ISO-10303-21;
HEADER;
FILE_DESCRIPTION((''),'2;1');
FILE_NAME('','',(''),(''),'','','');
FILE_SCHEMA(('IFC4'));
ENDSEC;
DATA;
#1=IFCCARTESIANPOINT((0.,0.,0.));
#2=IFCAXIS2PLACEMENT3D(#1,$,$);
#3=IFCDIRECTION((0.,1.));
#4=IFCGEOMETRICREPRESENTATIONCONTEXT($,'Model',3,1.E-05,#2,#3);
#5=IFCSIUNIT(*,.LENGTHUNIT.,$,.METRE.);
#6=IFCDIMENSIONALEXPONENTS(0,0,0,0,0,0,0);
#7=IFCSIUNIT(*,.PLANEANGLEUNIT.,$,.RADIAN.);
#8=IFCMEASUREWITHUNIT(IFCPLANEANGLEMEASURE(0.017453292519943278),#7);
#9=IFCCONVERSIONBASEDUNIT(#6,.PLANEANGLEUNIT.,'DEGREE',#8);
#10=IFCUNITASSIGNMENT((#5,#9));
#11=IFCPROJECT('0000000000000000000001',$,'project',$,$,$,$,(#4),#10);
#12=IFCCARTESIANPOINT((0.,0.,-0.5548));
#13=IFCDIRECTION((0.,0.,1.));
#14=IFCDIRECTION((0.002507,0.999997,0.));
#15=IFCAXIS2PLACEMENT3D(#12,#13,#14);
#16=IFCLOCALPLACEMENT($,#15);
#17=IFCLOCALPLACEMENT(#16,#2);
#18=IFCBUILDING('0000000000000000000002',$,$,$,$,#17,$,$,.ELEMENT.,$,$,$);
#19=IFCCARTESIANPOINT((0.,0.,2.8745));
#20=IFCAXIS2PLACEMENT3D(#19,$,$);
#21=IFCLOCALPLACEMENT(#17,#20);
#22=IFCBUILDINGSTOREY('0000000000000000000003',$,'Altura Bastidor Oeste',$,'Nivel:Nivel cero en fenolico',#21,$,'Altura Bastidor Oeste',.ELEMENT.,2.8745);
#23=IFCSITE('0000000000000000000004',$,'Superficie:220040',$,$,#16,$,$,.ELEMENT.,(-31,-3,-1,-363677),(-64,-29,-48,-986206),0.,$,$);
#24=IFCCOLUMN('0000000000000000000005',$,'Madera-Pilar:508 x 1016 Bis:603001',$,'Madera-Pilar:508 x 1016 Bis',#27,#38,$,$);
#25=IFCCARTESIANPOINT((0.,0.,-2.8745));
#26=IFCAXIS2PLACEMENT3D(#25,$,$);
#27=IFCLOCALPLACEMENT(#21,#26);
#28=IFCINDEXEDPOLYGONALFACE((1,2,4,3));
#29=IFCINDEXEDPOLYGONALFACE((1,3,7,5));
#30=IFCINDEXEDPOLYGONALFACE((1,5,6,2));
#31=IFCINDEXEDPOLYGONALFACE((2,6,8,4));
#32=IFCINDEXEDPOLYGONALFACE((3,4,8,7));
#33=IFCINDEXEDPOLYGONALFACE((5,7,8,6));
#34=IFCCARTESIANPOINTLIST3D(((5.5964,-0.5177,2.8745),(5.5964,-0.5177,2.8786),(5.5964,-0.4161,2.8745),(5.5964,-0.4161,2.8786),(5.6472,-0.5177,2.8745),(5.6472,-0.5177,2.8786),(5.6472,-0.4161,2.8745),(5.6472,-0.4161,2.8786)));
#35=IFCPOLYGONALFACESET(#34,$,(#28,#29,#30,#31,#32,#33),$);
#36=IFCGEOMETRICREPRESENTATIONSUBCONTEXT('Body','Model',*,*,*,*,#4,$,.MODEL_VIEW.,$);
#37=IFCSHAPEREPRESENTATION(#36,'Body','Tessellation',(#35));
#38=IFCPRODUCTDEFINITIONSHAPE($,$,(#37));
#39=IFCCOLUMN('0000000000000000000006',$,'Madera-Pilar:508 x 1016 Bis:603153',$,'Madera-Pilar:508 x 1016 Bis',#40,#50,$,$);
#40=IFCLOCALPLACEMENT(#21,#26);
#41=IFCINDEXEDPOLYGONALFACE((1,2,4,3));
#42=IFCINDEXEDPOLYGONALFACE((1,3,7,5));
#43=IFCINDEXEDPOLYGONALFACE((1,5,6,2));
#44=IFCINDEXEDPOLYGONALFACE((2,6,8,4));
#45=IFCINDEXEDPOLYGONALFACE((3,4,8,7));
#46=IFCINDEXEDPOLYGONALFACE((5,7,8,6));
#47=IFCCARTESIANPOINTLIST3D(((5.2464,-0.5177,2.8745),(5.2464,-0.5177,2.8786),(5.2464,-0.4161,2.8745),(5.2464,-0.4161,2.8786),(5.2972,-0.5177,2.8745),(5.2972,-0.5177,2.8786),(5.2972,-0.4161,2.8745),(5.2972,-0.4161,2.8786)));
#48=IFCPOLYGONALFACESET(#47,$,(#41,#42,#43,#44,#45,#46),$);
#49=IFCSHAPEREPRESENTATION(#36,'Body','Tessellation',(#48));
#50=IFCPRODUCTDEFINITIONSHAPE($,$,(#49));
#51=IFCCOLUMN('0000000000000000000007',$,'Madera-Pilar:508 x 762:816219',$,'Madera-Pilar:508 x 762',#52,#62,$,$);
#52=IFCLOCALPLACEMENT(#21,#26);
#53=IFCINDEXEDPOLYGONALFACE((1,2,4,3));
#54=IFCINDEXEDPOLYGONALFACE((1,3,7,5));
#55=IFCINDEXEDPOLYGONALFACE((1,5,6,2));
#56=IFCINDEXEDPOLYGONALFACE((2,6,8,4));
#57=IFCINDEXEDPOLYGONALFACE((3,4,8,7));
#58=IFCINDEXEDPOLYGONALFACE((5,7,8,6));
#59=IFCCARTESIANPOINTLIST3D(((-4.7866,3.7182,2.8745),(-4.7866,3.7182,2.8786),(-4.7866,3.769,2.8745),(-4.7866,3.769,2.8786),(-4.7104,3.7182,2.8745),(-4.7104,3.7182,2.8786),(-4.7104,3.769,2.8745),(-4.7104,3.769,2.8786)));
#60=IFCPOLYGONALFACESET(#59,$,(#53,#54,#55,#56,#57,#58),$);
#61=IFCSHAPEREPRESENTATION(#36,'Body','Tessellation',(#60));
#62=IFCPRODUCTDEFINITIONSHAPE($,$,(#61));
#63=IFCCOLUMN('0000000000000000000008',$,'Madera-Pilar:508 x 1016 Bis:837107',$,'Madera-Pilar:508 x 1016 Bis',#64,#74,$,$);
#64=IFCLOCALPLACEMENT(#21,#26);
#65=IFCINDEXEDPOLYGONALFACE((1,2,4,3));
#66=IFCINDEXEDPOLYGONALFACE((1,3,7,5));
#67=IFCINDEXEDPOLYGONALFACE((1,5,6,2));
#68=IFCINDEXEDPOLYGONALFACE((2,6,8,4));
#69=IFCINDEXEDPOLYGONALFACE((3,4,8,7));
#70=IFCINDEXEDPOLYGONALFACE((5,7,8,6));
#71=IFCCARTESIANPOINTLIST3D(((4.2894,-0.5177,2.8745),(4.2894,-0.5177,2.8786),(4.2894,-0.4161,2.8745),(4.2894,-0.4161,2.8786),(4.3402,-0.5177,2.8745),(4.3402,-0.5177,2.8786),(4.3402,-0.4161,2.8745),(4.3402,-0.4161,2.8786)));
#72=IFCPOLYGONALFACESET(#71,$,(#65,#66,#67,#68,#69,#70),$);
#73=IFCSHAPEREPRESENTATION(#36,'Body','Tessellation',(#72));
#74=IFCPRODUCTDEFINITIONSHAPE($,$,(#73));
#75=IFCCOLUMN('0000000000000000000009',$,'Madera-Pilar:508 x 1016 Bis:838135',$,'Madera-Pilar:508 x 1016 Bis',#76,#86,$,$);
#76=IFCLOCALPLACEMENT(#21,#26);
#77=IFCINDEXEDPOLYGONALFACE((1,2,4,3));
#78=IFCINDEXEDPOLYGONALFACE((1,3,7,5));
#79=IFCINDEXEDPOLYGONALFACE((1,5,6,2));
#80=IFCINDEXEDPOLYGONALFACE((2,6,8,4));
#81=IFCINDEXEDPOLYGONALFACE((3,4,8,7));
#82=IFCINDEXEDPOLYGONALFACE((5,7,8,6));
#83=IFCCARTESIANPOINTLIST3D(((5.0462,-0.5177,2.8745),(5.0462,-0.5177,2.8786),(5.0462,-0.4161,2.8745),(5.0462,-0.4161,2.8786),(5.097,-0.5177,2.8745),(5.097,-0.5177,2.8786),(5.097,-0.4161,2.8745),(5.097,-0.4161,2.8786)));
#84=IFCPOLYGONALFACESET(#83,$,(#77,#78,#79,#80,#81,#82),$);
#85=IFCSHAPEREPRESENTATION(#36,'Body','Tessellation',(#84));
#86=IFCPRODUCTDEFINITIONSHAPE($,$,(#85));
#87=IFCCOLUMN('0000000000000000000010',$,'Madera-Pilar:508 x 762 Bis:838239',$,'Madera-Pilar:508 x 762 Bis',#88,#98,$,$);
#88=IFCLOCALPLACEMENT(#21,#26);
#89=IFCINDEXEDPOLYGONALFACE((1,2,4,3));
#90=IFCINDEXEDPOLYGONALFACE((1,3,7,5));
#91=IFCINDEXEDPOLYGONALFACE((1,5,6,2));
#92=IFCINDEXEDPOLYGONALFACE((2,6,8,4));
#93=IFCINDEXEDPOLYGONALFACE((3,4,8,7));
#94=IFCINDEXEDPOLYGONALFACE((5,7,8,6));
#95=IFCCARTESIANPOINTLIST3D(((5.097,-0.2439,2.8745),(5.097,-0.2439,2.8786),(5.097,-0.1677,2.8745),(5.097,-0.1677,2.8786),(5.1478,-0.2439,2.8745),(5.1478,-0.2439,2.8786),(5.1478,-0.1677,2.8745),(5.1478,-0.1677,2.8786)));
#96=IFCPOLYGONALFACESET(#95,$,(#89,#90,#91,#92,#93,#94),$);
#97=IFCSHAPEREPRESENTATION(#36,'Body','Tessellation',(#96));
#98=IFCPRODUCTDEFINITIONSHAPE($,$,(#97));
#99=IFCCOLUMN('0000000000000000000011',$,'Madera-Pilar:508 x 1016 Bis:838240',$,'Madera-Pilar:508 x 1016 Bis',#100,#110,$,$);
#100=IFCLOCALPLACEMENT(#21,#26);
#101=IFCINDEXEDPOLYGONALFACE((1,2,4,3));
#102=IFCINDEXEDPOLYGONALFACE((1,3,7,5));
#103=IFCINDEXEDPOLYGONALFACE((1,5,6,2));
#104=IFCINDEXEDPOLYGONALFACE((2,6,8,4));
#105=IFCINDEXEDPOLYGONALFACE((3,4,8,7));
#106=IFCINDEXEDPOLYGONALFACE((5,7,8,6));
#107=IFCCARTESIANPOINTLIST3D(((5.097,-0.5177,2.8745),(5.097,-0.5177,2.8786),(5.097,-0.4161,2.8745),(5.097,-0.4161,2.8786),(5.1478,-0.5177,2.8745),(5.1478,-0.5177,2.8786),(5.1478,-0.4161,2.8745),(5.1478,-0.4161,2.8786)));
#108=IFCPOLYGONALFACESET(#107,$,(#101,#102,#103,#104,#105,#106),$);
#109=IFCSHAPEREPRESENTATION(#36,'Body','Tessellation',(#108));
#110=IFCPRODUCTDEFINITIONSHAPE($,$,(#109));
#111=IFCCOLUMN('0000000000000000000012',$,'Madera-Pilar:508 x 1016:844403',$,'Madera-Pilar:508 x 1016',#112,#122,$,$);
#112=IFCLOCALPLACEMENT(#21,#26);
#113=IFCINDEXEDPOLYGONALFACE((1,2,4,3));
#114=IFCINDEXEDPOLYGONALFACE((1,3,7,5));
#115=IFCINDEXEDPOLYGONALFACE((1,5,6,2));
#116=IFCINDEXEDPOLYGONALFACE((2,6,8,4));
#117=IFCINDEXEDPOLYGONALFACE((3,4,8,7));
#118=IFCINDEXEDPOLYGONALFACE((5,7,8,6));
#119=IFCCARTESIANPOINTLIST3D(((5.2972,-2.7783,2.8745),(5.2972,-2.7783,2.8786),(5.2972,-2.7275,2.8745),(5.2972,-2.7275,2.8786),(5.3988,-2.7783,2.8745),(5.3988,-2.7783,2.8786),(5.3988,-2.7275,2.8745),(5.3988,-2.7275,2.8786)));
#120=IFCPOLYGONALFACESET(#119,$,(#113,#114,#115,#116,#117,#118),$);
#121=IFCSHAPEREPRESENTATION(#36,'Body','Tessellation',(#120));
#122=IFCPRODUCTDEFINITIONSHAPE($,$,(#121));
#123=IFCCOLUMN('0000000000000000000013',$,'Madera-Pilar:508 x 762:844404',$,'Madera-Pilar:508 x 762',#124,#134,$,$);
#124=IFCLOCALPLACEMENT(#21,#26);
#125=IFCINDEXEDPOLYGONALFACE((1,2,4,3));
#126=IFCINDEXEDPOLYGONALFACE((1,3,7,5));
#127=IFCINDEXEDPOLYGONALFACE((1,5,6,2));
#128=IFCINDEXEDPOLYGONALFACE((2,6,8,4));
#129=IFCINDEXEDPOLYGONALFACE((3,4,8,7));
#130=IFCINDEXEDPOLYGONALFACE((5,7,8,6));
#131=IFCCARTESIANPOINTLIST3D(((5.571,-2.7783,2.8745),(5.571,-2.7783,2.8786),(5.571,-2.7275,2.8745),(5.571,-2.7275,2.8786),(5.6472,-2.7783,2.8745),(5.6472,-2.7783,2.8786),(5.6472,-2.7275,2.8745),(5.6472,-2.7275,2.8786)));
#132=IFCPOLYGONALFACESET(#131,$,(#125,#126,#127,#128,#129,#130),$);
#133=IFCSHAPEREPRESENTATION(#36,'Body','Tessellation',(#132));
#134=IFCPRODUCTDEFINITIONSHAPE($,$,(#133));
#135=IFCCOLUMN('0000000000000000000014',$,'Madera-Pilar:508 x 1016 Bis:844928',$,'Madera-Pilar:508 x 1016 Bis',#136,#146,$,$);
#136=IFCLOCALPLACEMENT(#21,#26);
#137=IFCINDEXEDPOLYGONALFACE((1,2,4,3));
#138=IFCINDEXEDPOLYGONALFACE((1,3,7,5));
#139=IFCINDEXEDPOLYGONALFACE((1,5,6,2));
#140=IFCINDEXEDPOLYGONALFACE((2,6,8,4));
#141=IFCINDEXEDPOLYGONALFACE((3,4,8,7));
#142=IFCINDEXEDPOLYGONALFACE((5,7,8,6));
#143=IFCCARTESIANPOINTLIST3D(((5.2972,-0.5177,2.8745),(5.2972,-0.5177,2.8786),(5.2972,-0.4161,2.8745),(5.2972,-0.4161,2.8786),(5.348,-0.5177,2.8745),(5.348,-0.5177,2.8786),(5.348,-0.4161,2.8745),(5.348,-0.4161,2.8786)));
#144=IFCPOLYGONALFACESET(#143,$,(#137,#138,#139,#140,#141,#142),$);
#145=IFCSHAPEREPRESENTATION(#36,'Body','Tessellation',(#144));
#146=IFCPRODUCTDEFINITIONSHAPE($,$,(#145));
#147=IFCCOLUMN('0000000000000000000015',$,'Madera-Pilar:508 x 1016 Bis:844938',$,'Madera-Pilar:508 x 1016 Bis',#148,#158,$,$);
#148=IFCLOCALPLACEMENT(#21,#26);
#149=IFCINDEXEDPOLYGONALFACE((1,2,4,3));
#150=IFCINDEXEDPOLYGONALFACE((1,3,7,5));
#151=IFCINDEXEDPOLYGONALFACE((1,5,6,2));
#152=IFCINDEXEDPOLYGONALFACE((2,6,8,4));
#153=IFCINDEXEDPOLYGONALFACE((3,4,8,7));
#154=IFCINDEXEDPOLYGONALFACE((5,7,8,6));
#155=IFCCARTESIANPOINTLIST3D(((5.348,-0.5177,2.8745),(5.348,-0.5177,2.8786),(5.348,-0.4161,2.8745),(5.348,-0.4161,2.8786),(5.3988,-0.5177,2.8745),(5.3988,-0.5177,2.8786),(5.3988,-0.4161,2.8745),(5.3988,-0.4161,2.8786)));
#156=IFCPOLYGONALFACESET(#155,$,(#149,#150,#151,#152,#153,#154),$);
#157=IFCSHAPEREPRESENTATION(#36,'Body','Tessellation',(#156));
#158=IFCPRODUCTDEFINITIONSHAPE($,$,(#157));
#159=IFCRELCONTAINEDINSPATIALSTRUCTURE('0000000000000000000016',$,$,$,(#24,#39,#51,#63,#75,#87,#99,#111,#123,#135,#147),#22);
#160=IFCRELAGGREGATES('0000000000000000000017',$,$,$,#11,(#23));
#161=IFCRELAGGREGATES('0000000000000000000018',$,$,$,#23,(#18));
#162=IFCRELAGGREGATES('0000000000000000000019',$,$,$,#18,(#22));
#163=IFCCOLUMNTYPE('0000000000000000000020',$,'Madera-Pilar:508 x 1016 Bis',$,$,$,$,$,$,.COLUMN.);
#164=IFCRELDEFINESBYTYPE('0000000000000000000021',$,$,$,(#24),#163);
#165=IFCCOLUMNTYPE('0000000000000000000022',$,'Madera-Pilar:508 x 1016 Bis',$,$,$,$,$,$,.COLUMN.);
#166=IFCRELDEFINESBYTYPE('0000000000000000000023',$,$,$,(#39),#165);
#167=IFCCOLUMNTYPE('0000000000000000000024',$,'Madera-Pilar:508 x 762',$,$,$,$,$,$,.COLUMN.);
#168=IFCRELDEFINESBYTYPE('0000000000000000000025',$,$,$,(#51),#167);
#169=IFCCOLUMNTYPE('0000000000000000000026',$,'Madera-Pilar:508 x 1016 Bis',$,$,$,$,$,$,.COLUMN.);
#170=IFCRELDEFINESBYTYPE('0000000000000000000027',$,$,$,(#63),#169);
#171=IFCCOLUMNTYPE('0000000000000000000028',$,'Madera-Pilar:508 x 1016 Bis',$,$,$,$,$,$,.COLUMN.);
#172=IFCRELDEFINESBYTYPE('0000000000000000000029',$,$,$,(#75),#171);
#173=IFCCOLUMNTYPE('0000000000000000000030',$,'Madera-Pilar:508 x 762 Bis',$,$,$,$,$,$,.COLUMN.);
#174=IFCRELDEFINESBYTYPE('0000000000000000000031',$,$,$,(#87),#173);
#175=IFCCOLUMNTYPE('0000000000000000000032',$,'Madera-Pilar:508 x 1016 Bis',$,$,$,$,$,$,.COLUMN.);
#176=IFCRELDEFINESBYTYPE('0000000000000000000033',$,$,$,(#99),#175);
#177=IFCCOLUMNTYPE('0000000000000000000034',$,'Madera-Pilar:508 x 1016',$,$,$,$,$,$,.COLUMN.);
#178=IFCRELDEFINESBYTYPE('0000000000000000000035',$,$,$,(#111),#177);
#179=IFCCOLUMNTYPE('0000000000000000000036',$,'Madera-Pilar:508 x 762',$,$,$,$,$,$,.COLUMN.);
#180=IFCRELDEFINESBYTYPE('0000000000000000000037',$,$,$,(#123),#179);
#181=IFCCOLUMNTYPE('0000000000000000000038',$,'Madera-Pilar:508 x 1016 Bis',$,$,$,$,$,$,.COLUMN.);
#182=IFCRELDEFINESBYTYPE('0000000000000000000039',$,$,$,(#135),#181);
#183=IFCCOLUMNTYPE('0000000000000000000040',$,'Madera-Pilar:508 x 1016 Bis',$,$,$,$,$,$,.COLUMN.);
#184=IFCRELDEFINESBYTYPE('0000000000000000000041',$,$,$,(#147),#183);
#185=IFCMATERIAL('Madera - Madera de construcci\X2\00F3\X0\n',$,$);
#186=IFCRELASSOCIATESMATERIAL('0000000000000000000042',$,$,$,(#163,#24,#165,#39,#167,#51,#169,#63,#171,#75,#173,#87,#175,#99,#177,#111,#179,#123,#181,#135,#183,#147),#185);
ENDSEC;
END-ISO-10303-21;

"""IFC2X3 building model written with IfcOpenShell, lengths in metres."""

from ifc_helpers import new_model, entity, si_unit, converted_unit, direction, frame, frame_2d, origin, origin_2d_with_axis, place, context, subcontext, project, spatial, rectangle, extrude, source, transform, mapped, material, type_object, type_shapes, element, save


model = new_model("IFC2X3")

# Units and contexts
model_context = context("Model", 3, precision=1e-05, world=origin(), true_north=direction((0.0, 1.0)))
body_context = subcontext(model_context, "Body", "Model", "MODEL_VIEW")
ifc_project = project(units=[si_unit("LENGTHUNIT", "METRE"), converted_unit("PLANEANGLEUNIT", "DEGREE", entity("IfcPlaneAngleMeasure", 0.017453292519943278), si_unit("PLANEANGLEUNIT", "RADIAN"), dimensions=[0, 0, 0, 0, 0, 0, 0])], contexts=[model_context])

# Site, building, storey
site_placement = place(None, frame((0.0, 0.0, -0.5548), z_axis=(0.0, 0.0, 1.0), x_axis=(0.002507, 0.999997, 0.0)))
site = spatial("IfcSite", under=ifc_project, at=site_placement, Name="Superficie:220040", CompositionType="ELEMENT", RefLatitude=(-31, -3, -1, -363677), RefLongitude=(-64, -29, -48, -986206), RefElevation=0.0)
building_placement = place(site_placement, origin())
building = spatial("IfcBuilding", under=site, at=building_placement, CompositionType="ELEMENT")
storey_placement = place(building_placement, frame((0.0, 0.0, 2.8745)))
storey = spatial("IfcBuildingStorey", under=building, at=storey_placement, Name="Altura Bastidor Oeste", ObjectType="Nivel:Nivel cero en fenolico", LongName="Altura Bastidor Oeste", CompositionType="ELEMENT", Elevation=2.8745)

# Columns
ifc_material_1 = material(Name="Madera - Madera de construcción")
column_type_1 = type_object("IfcColumnType", Name="Madera-Pilar:508 x 1016 Bis", PredefinedType="COLUMN", material=ifc_material_1)
shared_shape_1 = source(origin(), body_context, "Body", "SweptSolid", [
    extrude(rectangle(XDim=0.0508, YDim=0.1016, at=origin_2d_with_axis()), frame((5.6218, -0.4669, 2.8745)), (0.0, 0.0, 1.0), 0.0041),
])
type_shapes(column_type_1, [shared_shape_1])
column_1_placement = place(storey_placement, frame((0.0, 0.0, -2.8745)))
element("IfcColumn", 1, at=column_1_placement, inside=storey, type_object=column_type_1, material=ifc_material_1, Name="Madera-Pilar:508 x 1016 Bis:603001", ObjectType="Madera-Pilar:508 x 1016 Bis", context=body_context, shape_type="MappedRepresentation", body=[
    mapped(shared_shape_1, transform((0.0, 0.0, 0.0), scale=1.0)),
])
column_type_2 = type_object("IfcColumnType", Name="Madera-Pilar:508 x 1016 Bis", PredefinedType="COLUMN", material=ifc_material_1)
shared_shape_2 = source(origin(), body_context, "Body", "SweptSolid", [
    extrude(rectangle(XDim=0.0508, YDim=0.1016, at=frame_2d((0.0, 0.0), x_axis=(1.0, 0.0))), frame((5.2718, -0.4669, 2.8745)), (0.0, 0.0, 1.0), 0.0041),
])
type_shapes(column_type_2, [shared_shape_2])
column_2_placement = place(storey_placement, frame((0.0, 0.0, -2.8745)))
element("IfcColumn", 2, at=column_2_placement, inside=storey, type_object=column_type_2, material=ifc_material_1, Name="Madera-Pilar:508 x 1016 Bis:603153", ObjectType="Madera-Pilar:508 x 1016 Bis", context=body_context, shape_type="MappedRepresentation", body=[
    mapped(shared_shape_2, transform((0.0, 0.0, 0.0), scale=1.0)),
])
column_type_3 = type_object("IfcColumnType", Name="Madera-Pilar:508 x 762", PredefinedType="COLUMN", material=ifc_material_1)
shared_shape_3 = source(origin(), body_context, "Body", "SweptSolid", [
    extrude(rectangle(XDim=0.0762, YDim=0.0508, at=origin_2d_with_axis()), frame((-4.7485, 3.7436, 2.8745), z_axis=(0.0, 0.0, 1.0), x_axis=(-1.0, 0.0, 0.0)), (0.0, 0.0, 1.0), 0.0041),
])
type_shapes(column_type_3, [shared_shape_3])
column_3_placement = place(storey_placement, frame((0.0, 0.0, -2.8745)))
element("IfcColumn", 3, at=column_3_placement, inside=storey, type_object=column_type_3, material=ifc_material_1, Name="Madera-Pilar:508 x 762:816219", ObjectType="Madera-Pilar:508 x 762", context=body_context, shape_type="MappedRepresentation", body=[
    mapped(shared_shape_3, transform((0.0, 0.0, 0.0), scale=1.0)),
])
column_type_4 = type_object("IfcColumnType", Name="Madera-Pilar:508 x 1016 Bis", PredefinedType="COLUMN", material=ifc_material_1)
shared_shape_4 = source(origin(), body_context, "Body", "SweptSolid", [
    extrude(rectangle(XDim=0.0508, YDim=0.1016, at=frame_2d((0.0, 0.0), x_axis=(1.0, 0.0))), frame((4.3148, -0.4669, 2.8745)), (0.0, 0.0, 1.0), 0.0041),
])
type_shapes(column_type_4, [shared_shape_4])
column_4_placement = place(storey_placement, frame((0.0, 0.0, -2.8745)))
element("IfcColumn", 4, at=column_4_placement, inside=storey, type_object=column_type_4, material=ifc_material_1, Name="Madera-Pilar:508 x 1016 Bis:837107", ObjectType="Madera-Pilar:508 x 1016 Bis", context=body_context, shape_type="MappedRepresentation", body=[
    mapped(shared_shape_4, transform((0.0, 0.0, 0.0), scale=1.0)),
])
column_type_5 = type_object("IfcColumnType", Name="Madera-Pilar:508 x 1016 Bis", PredefinedType="COLUMN", material=ifc_material_1)
shared_shape_5 = source(origin(), body_context, "Body", "SweptSolid", [
    extrude(rectangle(XDim=0.0508, YDim=0.1016, at=frame_2d((0.0, 0.0), x_axis=(1.0, 0.0))), frame((5.0716, -0.4669, 2.8745)), (0.0, 0.0, 1.0), 0.0041),
])
type_shapes(column_type_5, [shared_shape_5])
column_5_placement = place(storey_placement, frame((0.0, 0.0, -2.8745)))
element("IfcColumn", 5, at=column_5_placement, inside=storey, type_object=column_type_5, material=ifc_material_1, Name="Madera-Pilar:508 x 1016 Bis:838135", ObjectType="Madera-Pilar:508 x 1016 Bis", context=body_context, shape_type="MappedRepresentation", body=[
    mapped(shared_shape_5, transform((0.0, 0.0, 0.0), scale=1.0)),
])
column_type_6 = type_object("IfcColumnType", Name="Madera-Pilar:508 x 762 Bis", PredefinedType="COLUMN", material=ifc_material_1)
shared_shape_6 = source(origin(), body_context, "Body", "SweptSolid", [
    extrude(rectangle(XDim=0.0508, YDim=0.0762, at=frame_2d((0.0, 0.0), x_axis=(1.0, 0.0))), frame((5.1224, -0.2058, 2.8745), z_axis=(0.0, 0.0, 1.0), x_axis=(-1.0, 0.0, 0.0)), (0.0, 0.0, 1.0), 0.0041),
])
type_shapes(column_type_6, [shared_shape_6])
column_6_placement = place(storey_placement, frame((0.0, 0.0, -2.8745)))
element("IfcColumn", 6, at=column_6_placement, inside=storey, type_object=column_type_6, material=ifc_material_1, Name="Madera-Pilar:508 x 762 Bis:838239", ObjectType="Madera-Pilar:508 x 762 Bis", context=body_context, shape_type="MappedRepresentation", body=[
    mapped(shared_shape_6, transform((0.0, 0.0, 0.0), scale=1.0)),
])
column_type_7 = type_object("IfcColumnType", Name="Madera-Pilar:508 x 1016 Bis", PredefinedType="COLUMN", material=ifc_material_1)
shared_shape_7 = source(origin(), body_context, "Body", "SweptSolid", [
    extrude(rectangle(XDim=0.0508, YDim=0.1016, at=origin_2d_with_axis()), frame((5.1224, -0.4669, 2.8745)), (0.0, 0.0, 1.0), 0.0041),
])
type_shapes(column_type_7, [shared_shape_7])
column_7_placement = place(storey_placement, frame((0.0, 0.0, -2.8745)))
element("IfcColumn", 7, at=column_7_placement, inside=storey, type_object=column_type_7, material=ifc_material_1, Name="Madera-Pilar:508 x 1016 Bis:838240", ObjectType="Madera-Pilar:508 x 1016 Bis", context=body_context, shape_type="MappedRepresentation", body=[
    mapped(shared_shape_7, transform((0.0, 0.0, 0.0), scale=1.0)),
])
column_type_8 = type_object("IfcColumnType", Name="Madera-Pilar:508 x 1016", PredefinedType="COLUMN", material=ifc_material_1)
shared_shape_8 = source(origin(), body_context, "Body", "SweptSolid", [
    extrude(rectangle(XDim=0.1016, YDim=0.0508, at=origin_2d_with_axis()), frame((5.348, -2.7529, 2.8745), z_axis=(0.0, 0.0, 1.0), x_axis=(-1.0, 0.0, 0.0)), (0.0, 0.0, 1.0), 0.0041),
])
type_shapes(column_type_8, [shared_shape_8])
column_8_placement = place(storey_placement, frame((0.0, 0.0, -2.8745)))
element("IfcColumn", 8, at=column_8_placement, inside=storey, type_object=column_type_8, material=ifc_material_1, Name="Madera-Pilar:508 x 1016:844403", ObjectType="Madera-Pilar:508 x 1016", context=body_context, shape_type="MappedRepresentation", body=[
    mapped(shared_shape_8, transform((0.0, 0.0, 0.0), scale=1.0)),
])
column_type_9 = type_object("IfcColumnType", Name="Madera-Pilar:508 x 762", PredefinedType="COLUMN", material=ifc_material_1)
shared_shape_9 = source(origin(), body_context, "Body", "SweptSolid", [
    extrude(rectangle(XDim=0.0762, YDim=0.0508, at=origin_2d_with_axis()), frame((5.6091, -2.7529, 2.8745), z_axis=(0.0, 0.0, 1.0), x_axis=(-1.0, 0.0, 0.0)), (0.0, 0.0, 1.0), 0.0041),
])
type_shapes(column_type_9, [shared_shape_9])
column_9_placement = place(storey_placement, frame((0.0, 0.0, -2.8745)))
element("IfcColumn", 9, at=column_9_placement, inside=storey, type_object=column_type_9, material=ifc_material_1, Name="Madera-Pilar:508 x 762:844404", ObjectType="Madera-Pilar:508 x 762", context=body_context, shape_type="MappedRepresentation", body=[
    mapped(shared_shape_9, transform((0.0, 0.0, 0.0), scale=1.0)),
])
column_type_10 = type_object("IfcColumnType", Name="Madera-Pilar:508 x 1016 Bis", PredefinedType="COLUMN", material=ifc_material_1)
shared_shape_10 = source(origin(), body_context, "Body", "SweptSolid", [
    extrude(rectangle(XDim=0.0508, YDim=0.1016, at=frame_2d((0.0, 0.0), x_axis=(1.0, 0.0))), frame((5.3226, -0.4669, 2.8745)), (0.0, 0.0, 1.0), 0.0041),
])
type_shapes(column_type_10, [shared_shape_10])
column_10_placement = place(storey_placement, frame((0.0, 0.0, -2.8745)))
element("IfcColumn", 10, at=column_10_placement, inside=storey, type_object=column_type_10, material=ifc_material_1, Name="Madera-Pilar:508 x 1016 Bis:844928", ObjectType="Madera-Pilar:508 x 1016 Bis", context=body_context, shape_type="MappedRepresentation", body=[
    mapped(shared_shape_10, transform((0.0, 0.0, 0.0), scale=1.0)),
])
column_type_11 = type_object("IfcColumnType", Name="Madera-Pilar:508 x 1016 Bis", PredefinedType="COLUMN", material=ifc_material_1)
shared_shape_11 = source(origin(), body_context, "Body", "SweptSolid", [
    extrude(rectangle(XDim=0.0508, YDim=0.1016, at=frame_2d((0.0, 0.0), x_axis=(1.0, 0.0))), frame((5.3734, -0.4669, 2.8745)), (0.0, 0.0, 1.0), 0.0041),
])
type_shapes(column_type_11, [shared_shape_11])
column_11_placement = place(storey_placement, frame((0.0, 0.0, -2.8745)))
element("IfcColumn", 11, at=column_11_placement, inside=storey, type_object=column_type_11, material=ifc_material_1, Name="Madera-Pilar:508 x 1016 Bis:844938", ObjectType="Madera-Pilar:508 x 1016 Bis", context=body_context, shape_type="MappedRepresentation", body=[
    mapped(shared_shape_11, transform((0.0, 0.0, 0.0), scale=1.0)),
])

save(model, "model.ifc")
